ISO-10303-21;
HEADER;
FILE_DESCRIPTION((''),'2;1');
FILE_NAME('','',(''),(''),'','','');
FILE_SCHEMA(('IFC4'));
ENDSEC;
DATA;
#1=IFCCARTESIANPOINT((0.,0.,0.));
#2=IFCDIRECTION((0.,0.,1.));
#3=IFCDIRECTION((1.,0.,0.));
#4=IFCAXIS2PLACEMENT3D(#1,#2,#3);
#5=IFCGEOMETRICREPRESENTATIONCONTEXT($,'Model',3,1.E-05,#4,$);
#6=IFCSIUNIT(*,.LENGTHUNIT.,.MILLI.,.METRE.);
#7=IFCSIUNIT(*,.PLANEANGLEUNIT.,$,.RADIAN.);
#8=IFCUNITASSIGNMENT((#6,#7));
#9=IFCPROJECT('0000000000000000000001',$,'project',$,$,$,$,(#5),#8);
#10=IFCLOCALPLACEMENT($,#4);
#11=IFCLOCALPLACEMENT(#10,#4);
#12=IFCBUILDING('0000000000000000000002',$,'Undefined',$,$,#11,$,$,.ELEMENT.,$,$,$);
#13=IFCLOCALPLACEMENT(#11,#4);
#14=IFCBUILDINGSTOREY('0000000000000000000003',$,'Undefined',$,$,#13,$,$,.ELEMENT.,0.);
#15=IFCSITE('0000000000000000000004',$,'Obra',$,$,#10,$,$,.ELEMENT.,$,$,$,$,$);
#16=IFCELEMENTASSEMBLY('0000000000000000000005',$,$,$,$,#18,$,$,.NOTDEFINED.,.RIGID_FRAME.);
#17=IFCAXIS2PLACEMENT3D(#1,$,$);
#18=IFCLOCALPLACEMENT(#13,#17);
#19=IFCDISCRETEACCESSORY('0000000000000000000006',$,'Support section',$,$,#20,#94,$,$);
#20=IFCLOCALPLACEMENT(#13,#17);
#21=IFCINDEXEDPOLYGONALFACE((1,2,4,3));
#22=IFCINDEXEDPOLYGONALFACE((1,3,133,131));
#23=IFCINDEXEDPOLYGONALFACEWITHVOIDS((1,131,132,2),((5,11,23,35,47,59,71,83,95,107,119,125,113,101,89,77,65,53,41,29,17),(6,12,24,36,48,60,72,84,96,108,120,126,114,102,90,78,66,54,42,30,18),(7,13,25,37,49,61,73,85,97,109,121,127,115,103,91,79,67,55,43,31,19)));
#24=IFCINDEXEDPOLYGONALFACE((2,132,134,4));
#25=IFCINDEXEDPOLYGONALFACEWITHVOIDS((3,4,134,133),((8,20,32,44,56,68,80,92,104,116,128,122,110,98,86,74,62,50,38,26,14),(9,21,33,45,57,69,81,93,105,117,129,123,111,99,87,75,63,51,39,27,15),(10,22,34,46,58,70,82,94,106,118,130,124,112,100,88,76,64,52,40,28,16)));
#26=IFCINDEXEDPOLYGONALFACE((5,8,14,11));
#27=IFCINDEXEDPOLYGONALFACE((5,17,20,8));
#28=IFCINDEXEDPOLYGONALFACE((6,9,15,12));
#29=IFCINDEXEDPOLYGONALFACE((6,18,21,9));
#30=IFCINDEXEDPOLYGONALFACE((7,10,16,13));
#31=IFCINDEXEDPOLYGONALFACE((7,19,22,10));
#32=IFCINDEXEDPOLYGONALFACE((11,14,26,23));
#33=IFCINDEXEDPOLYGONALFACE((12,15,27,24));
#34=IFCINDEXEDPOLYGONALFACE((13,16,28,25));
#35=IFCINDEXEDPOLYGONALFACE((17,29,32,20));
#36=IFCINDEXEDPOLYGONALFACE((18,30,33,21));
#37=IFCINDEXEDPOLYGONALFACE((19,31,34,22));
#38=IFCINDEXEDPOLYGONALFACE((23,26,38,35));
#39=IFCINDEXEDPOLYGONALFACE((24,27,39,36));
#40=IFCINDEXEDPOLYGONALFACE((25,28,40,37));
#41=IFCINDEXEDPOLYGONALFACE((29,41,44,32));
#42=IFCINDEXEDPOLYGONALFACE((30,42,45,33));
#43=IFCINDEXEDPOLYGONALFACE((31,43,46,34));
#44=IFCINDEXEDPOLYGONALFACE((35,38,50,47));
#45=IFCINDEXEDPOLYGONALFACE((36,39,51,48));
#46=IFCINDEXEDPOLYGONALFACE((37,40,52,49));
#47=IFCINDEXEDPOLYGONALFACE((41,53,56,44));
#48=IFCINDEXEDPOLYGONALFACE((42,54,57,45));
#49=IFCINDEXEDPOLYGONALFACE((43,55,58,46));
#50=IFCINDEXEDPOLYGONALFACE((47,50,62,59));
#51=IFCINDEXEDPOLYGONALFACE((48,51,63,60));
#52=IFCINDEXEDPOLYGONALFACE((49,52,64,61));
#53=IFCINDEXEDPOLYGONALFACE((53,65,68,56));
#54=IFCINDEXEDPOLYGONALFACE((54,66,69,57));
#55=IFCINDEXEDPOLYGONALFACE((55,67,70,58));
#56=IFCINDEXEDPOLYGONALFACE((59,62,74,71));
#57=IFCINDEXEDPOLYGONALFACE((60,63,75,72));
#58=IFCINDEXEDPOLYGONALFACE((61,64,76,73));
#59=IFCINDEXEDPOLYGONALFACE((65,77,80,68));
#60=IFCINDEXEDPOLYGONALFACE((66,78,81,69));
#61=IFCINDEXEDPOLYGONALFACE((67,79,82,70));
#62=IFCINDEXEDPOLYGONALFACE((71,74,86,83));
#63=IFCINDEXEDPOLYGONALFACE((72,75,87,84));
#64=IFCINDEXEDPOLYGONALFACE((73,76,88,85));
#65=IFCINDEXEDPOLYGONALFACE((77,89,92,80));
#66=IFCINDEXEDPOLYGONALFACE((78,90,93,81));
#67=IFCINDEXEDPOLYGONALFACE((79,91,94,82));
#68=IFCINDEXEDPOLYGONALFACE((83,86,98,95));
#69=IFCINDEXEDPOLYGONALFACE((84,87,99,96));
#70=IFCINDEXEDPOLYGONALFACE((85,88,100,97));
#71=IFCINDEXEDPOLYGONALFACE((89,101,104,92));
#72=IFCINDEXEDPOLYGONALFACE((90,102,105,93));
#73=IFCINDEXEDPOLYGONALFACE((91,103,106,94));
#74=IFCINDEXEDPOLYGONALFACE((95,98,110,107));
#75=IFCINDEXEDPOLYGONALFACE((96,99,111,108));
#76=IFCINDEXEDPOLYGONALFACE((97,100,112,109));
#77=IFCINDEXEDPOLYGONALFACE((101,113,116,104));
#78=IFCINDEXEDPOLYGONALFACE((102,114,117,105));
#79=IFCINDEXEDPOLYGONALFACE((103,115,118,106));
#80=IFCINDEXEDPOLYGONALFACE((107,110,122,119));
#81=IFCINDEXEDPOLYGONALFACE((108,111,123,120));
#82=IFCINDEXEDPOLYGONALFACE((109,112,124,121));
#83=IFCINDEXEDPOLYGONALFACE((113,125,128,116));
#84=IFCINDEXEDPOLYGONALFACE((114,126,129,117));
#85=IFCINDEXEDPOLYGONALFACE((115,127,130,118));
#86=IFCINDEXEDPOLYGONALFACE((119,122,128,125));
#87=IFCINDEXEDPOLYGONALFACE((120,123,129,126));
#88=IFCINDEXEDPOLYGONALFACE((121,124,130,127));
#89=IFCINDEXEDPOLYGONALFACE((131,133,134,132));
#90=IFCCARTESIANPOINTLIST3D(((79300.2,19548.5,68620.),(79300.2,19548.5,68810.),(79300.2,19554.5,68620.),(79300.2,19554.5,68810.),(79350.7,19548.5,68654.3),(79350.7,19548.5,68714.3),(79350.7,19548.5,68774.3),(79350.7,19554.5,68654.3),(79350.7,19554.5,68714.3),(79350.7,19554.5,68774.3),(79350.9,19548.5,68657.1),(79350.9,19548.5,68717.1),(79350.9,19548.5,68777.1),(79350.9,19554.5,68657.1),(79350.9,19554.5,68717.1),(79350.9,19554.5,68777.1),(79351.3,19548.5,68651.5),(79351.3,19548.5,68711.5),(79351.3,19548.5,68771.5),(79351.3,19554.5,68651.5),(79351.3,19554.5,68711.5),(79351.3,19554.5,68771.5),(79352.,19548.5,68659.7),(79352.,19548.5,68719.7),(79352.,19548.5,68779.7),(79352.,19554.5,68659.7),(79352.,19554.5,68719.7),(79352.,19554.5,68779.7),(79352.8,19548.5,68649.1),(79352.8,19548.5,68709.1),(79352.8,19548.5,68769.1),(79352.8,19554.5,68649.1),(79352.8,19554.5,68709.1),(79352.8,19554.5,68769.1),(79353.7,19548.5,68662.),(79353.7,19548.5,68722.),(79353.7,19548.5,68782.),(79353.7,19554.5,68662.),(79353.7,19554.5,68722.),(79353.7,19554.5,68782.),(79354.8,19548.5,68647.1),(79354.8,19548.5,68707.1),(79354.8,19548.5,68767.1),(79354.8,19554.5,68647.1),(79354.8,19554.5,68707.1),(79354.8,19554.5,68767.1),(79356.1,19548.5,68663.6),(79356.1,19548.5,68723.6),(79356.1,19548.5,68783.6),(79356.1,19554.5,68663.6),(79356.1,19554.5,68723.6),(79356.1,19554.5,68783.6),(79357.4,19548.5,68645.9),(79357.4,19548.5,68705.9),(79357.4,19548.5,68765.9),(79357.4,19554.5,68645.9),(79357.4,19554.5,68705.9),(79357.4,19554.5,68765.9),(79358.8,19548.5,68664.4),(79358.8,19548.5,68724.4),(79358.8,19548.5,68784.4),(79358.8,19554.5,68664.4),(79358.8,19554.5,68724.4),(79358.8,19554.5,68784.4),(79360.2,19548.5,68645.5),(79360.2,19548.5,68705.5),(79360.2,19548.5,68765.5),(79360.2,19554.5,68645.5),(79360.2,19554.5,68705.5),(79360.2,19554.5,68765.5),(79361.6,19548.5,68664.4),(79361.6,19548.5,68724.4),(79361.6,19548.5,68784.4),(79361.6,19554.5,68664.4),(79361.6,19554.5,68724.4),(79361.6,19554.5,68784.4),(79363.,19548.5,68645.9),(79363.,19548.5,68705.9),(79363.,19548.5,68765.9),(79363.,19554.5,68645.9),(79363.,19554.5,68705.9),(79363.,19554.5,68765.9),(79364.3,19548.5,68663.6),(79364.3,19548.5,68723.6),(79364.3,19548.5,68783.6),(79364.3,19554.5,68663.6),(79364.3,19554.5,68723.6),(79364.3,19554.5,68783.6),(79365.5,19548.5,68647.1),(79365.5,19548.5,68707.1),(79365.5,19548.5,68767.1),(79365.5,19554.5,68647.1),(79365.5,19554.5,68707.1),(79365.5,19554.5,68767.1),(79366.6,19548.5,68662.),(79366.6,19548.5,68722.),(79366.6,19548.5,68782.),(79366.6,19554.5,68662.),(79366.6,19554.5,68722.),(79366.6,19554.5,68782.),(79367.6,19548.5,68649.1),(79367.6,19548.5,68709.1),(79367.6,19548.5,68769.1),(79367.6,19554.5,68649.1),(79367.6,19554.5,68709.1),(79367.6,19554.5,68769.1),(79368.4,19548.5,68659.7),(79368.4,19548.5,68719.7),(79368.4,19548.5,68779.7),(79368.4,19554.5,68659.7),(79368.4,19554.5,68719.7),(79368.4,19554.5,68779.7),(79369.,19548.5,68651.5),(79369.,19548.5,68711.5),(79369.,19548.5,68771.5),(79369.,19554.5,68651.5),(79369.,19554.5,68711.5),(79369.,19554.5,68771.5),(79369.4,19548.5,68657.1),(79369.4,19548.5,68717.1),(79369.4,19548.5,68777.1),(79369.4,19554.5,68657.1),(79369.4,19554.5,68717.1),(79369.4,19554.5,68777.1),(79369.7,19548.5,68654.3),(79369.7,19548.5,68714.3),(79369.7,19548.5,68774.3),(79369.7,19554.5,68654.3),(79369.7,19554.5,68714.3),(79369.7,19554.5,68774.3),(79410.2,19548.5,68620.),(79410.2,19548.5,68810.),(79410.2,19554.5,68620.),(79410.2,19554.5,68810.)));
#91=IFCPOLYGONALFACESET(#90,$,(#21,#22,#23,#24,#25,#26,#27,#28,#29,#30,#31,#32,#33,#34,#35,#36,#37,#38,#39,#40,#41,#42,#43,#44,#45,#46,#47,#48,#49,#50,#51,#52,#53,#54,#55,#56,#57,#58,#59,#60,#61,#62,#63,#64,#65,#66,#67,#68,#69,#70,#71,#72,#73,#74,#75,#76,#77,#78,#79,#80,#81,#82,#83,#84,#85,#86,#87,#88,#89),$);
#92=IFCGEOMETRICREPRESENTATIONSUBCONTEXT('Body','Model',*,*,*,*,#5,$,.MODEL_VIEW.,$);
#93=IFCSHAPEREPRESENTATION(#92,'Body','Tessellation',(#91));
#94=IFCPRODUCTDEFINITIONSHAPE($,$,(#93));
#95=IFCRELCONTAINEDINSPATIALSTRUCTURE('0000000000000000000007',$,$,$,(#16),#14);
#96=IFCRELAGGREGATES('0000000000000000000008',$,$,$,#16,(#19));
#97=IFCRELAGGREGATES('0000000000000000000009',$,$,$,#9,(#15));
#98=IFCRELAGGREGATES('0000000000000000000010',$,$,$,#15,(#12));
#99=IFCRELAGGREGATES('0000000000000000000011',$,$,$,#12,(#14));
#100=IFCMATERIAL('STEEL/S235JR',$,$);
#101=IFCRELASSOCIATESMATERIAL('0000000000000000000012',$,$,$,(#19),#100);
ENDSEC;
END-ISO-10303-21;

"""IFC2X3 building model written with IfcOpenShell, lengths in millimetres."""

from ifc_helpers import new_model, si_unit, frame, origin_with_axes, origin_2d_with_axis, place, context, subcontext, project, spatial, rectangle, circle, extrude, source, transform, mapped, material, element, aggregate, save


model = new_model("IFC2X3")

# Units and contexts
model_context = context("Model", 3, precision=1e-05, world=origin_with_axes())
body_context = subcontext(model_context, "Body", "Model", "MODEL_VIEW")
ifc_project = project(units=[si_unit("LENGTHUNIT", "METRE", prefix="MILLI"), si_unit("PLANEANGLEUNIT", "RADIAN")], contexts=[model_context])

# Site, building, storey
site_placement = place(None, origin_with_axes())
site = spatial("IfcSite", under=ifc_project, at=site_placement, Name="Obra", CompositionType="ELEMENT")
building_placement = place(site_placement, origin_with_axes())
building = spatial("IfcBuilding", under=site, at=building_placement, Name="Undefined", CompositionType="ELEMENT")
storey_placement = place(building_placement, origin_with_axes())
storey = spatial("IfcBuildingStorey", under=building, at=storey_placement, Name="Undefined", CompositionType="ELEMENT", Elevation=0.0)

# Element assembly
assembly_1_placement = place(storey_placement, origin_with_axes())
assembly_1 = element("IfcElementAssembly", 1, at=assembly_1_placement, inside=storey, AssemblyPlace="NOTDEFINED", PredefinedType="RIGID_FRAME")
ifc_material = material(Name="STEEL/S235JR")

# Discrete accessory, opening
discrete_accessory_1_placement = place(assembly_1_placement, frame((79355.2, 19551.5, 68620.0), z_axis=(0.0, 0.0, 1.0), x_axis=(-1.0, 0.0, 0.0)))
discrete_accessory_1 = element("IfcDiscreteAccessory", 2, at=discrete_accessory_1_placement, material=ifc_material, Name="Support section", context=body_context, shape_type="SweptSolid", body=[
    extrude(rectangle(XDim=6.0, YDim=110.0, at=origin_2d_with_axis()), frame((0.0, 0.0, 190.0), z_axis=(0.0, 0.0, -1.0), x_axis=(0.0, 1.0, 0.0)), (0.0, 0.0, 1.0), 190.0),
])
shared_shape_1 = source(origin_with_axes(), body_context, "Body", "SweptSolid", [
    extrude(circle(Radius=9.5, at=origin_2d_with_axis()), frame((0.0, -9.2, 0.0), z_axis=(0.0, 1.0, 0.0), x_axis=(1.0, 0.0, 0.0)), (0.0, 0.0, 1.0), 6.2),
])
opening_1_placement = place(assembly_1_placement, frame((79310.2, 19557.6, 68835.0), z_axis=(1.0, 0.0, 0.0), x_axis=(0.0, 0.0, -1.0)))
element("IfcOpeningElement", 3, at=opening_1_placement, cuts=discrete_accessory_1, ObjectType="Opening", context=body_context, shape_type="MappedRepresentation", body=[
    mapped(shared_shape_1, transform((60.0, 0.0, 50.0))),
    mapped(shared_shape_1, transform((120.0, 0.0, 50.0))),
    mapped(shared_shape_1, transform((180.0, 0.0, 50.0))),
])
aggregate(assembly_1, [discrete_accessory_1])

save(model, "model.ifc")
